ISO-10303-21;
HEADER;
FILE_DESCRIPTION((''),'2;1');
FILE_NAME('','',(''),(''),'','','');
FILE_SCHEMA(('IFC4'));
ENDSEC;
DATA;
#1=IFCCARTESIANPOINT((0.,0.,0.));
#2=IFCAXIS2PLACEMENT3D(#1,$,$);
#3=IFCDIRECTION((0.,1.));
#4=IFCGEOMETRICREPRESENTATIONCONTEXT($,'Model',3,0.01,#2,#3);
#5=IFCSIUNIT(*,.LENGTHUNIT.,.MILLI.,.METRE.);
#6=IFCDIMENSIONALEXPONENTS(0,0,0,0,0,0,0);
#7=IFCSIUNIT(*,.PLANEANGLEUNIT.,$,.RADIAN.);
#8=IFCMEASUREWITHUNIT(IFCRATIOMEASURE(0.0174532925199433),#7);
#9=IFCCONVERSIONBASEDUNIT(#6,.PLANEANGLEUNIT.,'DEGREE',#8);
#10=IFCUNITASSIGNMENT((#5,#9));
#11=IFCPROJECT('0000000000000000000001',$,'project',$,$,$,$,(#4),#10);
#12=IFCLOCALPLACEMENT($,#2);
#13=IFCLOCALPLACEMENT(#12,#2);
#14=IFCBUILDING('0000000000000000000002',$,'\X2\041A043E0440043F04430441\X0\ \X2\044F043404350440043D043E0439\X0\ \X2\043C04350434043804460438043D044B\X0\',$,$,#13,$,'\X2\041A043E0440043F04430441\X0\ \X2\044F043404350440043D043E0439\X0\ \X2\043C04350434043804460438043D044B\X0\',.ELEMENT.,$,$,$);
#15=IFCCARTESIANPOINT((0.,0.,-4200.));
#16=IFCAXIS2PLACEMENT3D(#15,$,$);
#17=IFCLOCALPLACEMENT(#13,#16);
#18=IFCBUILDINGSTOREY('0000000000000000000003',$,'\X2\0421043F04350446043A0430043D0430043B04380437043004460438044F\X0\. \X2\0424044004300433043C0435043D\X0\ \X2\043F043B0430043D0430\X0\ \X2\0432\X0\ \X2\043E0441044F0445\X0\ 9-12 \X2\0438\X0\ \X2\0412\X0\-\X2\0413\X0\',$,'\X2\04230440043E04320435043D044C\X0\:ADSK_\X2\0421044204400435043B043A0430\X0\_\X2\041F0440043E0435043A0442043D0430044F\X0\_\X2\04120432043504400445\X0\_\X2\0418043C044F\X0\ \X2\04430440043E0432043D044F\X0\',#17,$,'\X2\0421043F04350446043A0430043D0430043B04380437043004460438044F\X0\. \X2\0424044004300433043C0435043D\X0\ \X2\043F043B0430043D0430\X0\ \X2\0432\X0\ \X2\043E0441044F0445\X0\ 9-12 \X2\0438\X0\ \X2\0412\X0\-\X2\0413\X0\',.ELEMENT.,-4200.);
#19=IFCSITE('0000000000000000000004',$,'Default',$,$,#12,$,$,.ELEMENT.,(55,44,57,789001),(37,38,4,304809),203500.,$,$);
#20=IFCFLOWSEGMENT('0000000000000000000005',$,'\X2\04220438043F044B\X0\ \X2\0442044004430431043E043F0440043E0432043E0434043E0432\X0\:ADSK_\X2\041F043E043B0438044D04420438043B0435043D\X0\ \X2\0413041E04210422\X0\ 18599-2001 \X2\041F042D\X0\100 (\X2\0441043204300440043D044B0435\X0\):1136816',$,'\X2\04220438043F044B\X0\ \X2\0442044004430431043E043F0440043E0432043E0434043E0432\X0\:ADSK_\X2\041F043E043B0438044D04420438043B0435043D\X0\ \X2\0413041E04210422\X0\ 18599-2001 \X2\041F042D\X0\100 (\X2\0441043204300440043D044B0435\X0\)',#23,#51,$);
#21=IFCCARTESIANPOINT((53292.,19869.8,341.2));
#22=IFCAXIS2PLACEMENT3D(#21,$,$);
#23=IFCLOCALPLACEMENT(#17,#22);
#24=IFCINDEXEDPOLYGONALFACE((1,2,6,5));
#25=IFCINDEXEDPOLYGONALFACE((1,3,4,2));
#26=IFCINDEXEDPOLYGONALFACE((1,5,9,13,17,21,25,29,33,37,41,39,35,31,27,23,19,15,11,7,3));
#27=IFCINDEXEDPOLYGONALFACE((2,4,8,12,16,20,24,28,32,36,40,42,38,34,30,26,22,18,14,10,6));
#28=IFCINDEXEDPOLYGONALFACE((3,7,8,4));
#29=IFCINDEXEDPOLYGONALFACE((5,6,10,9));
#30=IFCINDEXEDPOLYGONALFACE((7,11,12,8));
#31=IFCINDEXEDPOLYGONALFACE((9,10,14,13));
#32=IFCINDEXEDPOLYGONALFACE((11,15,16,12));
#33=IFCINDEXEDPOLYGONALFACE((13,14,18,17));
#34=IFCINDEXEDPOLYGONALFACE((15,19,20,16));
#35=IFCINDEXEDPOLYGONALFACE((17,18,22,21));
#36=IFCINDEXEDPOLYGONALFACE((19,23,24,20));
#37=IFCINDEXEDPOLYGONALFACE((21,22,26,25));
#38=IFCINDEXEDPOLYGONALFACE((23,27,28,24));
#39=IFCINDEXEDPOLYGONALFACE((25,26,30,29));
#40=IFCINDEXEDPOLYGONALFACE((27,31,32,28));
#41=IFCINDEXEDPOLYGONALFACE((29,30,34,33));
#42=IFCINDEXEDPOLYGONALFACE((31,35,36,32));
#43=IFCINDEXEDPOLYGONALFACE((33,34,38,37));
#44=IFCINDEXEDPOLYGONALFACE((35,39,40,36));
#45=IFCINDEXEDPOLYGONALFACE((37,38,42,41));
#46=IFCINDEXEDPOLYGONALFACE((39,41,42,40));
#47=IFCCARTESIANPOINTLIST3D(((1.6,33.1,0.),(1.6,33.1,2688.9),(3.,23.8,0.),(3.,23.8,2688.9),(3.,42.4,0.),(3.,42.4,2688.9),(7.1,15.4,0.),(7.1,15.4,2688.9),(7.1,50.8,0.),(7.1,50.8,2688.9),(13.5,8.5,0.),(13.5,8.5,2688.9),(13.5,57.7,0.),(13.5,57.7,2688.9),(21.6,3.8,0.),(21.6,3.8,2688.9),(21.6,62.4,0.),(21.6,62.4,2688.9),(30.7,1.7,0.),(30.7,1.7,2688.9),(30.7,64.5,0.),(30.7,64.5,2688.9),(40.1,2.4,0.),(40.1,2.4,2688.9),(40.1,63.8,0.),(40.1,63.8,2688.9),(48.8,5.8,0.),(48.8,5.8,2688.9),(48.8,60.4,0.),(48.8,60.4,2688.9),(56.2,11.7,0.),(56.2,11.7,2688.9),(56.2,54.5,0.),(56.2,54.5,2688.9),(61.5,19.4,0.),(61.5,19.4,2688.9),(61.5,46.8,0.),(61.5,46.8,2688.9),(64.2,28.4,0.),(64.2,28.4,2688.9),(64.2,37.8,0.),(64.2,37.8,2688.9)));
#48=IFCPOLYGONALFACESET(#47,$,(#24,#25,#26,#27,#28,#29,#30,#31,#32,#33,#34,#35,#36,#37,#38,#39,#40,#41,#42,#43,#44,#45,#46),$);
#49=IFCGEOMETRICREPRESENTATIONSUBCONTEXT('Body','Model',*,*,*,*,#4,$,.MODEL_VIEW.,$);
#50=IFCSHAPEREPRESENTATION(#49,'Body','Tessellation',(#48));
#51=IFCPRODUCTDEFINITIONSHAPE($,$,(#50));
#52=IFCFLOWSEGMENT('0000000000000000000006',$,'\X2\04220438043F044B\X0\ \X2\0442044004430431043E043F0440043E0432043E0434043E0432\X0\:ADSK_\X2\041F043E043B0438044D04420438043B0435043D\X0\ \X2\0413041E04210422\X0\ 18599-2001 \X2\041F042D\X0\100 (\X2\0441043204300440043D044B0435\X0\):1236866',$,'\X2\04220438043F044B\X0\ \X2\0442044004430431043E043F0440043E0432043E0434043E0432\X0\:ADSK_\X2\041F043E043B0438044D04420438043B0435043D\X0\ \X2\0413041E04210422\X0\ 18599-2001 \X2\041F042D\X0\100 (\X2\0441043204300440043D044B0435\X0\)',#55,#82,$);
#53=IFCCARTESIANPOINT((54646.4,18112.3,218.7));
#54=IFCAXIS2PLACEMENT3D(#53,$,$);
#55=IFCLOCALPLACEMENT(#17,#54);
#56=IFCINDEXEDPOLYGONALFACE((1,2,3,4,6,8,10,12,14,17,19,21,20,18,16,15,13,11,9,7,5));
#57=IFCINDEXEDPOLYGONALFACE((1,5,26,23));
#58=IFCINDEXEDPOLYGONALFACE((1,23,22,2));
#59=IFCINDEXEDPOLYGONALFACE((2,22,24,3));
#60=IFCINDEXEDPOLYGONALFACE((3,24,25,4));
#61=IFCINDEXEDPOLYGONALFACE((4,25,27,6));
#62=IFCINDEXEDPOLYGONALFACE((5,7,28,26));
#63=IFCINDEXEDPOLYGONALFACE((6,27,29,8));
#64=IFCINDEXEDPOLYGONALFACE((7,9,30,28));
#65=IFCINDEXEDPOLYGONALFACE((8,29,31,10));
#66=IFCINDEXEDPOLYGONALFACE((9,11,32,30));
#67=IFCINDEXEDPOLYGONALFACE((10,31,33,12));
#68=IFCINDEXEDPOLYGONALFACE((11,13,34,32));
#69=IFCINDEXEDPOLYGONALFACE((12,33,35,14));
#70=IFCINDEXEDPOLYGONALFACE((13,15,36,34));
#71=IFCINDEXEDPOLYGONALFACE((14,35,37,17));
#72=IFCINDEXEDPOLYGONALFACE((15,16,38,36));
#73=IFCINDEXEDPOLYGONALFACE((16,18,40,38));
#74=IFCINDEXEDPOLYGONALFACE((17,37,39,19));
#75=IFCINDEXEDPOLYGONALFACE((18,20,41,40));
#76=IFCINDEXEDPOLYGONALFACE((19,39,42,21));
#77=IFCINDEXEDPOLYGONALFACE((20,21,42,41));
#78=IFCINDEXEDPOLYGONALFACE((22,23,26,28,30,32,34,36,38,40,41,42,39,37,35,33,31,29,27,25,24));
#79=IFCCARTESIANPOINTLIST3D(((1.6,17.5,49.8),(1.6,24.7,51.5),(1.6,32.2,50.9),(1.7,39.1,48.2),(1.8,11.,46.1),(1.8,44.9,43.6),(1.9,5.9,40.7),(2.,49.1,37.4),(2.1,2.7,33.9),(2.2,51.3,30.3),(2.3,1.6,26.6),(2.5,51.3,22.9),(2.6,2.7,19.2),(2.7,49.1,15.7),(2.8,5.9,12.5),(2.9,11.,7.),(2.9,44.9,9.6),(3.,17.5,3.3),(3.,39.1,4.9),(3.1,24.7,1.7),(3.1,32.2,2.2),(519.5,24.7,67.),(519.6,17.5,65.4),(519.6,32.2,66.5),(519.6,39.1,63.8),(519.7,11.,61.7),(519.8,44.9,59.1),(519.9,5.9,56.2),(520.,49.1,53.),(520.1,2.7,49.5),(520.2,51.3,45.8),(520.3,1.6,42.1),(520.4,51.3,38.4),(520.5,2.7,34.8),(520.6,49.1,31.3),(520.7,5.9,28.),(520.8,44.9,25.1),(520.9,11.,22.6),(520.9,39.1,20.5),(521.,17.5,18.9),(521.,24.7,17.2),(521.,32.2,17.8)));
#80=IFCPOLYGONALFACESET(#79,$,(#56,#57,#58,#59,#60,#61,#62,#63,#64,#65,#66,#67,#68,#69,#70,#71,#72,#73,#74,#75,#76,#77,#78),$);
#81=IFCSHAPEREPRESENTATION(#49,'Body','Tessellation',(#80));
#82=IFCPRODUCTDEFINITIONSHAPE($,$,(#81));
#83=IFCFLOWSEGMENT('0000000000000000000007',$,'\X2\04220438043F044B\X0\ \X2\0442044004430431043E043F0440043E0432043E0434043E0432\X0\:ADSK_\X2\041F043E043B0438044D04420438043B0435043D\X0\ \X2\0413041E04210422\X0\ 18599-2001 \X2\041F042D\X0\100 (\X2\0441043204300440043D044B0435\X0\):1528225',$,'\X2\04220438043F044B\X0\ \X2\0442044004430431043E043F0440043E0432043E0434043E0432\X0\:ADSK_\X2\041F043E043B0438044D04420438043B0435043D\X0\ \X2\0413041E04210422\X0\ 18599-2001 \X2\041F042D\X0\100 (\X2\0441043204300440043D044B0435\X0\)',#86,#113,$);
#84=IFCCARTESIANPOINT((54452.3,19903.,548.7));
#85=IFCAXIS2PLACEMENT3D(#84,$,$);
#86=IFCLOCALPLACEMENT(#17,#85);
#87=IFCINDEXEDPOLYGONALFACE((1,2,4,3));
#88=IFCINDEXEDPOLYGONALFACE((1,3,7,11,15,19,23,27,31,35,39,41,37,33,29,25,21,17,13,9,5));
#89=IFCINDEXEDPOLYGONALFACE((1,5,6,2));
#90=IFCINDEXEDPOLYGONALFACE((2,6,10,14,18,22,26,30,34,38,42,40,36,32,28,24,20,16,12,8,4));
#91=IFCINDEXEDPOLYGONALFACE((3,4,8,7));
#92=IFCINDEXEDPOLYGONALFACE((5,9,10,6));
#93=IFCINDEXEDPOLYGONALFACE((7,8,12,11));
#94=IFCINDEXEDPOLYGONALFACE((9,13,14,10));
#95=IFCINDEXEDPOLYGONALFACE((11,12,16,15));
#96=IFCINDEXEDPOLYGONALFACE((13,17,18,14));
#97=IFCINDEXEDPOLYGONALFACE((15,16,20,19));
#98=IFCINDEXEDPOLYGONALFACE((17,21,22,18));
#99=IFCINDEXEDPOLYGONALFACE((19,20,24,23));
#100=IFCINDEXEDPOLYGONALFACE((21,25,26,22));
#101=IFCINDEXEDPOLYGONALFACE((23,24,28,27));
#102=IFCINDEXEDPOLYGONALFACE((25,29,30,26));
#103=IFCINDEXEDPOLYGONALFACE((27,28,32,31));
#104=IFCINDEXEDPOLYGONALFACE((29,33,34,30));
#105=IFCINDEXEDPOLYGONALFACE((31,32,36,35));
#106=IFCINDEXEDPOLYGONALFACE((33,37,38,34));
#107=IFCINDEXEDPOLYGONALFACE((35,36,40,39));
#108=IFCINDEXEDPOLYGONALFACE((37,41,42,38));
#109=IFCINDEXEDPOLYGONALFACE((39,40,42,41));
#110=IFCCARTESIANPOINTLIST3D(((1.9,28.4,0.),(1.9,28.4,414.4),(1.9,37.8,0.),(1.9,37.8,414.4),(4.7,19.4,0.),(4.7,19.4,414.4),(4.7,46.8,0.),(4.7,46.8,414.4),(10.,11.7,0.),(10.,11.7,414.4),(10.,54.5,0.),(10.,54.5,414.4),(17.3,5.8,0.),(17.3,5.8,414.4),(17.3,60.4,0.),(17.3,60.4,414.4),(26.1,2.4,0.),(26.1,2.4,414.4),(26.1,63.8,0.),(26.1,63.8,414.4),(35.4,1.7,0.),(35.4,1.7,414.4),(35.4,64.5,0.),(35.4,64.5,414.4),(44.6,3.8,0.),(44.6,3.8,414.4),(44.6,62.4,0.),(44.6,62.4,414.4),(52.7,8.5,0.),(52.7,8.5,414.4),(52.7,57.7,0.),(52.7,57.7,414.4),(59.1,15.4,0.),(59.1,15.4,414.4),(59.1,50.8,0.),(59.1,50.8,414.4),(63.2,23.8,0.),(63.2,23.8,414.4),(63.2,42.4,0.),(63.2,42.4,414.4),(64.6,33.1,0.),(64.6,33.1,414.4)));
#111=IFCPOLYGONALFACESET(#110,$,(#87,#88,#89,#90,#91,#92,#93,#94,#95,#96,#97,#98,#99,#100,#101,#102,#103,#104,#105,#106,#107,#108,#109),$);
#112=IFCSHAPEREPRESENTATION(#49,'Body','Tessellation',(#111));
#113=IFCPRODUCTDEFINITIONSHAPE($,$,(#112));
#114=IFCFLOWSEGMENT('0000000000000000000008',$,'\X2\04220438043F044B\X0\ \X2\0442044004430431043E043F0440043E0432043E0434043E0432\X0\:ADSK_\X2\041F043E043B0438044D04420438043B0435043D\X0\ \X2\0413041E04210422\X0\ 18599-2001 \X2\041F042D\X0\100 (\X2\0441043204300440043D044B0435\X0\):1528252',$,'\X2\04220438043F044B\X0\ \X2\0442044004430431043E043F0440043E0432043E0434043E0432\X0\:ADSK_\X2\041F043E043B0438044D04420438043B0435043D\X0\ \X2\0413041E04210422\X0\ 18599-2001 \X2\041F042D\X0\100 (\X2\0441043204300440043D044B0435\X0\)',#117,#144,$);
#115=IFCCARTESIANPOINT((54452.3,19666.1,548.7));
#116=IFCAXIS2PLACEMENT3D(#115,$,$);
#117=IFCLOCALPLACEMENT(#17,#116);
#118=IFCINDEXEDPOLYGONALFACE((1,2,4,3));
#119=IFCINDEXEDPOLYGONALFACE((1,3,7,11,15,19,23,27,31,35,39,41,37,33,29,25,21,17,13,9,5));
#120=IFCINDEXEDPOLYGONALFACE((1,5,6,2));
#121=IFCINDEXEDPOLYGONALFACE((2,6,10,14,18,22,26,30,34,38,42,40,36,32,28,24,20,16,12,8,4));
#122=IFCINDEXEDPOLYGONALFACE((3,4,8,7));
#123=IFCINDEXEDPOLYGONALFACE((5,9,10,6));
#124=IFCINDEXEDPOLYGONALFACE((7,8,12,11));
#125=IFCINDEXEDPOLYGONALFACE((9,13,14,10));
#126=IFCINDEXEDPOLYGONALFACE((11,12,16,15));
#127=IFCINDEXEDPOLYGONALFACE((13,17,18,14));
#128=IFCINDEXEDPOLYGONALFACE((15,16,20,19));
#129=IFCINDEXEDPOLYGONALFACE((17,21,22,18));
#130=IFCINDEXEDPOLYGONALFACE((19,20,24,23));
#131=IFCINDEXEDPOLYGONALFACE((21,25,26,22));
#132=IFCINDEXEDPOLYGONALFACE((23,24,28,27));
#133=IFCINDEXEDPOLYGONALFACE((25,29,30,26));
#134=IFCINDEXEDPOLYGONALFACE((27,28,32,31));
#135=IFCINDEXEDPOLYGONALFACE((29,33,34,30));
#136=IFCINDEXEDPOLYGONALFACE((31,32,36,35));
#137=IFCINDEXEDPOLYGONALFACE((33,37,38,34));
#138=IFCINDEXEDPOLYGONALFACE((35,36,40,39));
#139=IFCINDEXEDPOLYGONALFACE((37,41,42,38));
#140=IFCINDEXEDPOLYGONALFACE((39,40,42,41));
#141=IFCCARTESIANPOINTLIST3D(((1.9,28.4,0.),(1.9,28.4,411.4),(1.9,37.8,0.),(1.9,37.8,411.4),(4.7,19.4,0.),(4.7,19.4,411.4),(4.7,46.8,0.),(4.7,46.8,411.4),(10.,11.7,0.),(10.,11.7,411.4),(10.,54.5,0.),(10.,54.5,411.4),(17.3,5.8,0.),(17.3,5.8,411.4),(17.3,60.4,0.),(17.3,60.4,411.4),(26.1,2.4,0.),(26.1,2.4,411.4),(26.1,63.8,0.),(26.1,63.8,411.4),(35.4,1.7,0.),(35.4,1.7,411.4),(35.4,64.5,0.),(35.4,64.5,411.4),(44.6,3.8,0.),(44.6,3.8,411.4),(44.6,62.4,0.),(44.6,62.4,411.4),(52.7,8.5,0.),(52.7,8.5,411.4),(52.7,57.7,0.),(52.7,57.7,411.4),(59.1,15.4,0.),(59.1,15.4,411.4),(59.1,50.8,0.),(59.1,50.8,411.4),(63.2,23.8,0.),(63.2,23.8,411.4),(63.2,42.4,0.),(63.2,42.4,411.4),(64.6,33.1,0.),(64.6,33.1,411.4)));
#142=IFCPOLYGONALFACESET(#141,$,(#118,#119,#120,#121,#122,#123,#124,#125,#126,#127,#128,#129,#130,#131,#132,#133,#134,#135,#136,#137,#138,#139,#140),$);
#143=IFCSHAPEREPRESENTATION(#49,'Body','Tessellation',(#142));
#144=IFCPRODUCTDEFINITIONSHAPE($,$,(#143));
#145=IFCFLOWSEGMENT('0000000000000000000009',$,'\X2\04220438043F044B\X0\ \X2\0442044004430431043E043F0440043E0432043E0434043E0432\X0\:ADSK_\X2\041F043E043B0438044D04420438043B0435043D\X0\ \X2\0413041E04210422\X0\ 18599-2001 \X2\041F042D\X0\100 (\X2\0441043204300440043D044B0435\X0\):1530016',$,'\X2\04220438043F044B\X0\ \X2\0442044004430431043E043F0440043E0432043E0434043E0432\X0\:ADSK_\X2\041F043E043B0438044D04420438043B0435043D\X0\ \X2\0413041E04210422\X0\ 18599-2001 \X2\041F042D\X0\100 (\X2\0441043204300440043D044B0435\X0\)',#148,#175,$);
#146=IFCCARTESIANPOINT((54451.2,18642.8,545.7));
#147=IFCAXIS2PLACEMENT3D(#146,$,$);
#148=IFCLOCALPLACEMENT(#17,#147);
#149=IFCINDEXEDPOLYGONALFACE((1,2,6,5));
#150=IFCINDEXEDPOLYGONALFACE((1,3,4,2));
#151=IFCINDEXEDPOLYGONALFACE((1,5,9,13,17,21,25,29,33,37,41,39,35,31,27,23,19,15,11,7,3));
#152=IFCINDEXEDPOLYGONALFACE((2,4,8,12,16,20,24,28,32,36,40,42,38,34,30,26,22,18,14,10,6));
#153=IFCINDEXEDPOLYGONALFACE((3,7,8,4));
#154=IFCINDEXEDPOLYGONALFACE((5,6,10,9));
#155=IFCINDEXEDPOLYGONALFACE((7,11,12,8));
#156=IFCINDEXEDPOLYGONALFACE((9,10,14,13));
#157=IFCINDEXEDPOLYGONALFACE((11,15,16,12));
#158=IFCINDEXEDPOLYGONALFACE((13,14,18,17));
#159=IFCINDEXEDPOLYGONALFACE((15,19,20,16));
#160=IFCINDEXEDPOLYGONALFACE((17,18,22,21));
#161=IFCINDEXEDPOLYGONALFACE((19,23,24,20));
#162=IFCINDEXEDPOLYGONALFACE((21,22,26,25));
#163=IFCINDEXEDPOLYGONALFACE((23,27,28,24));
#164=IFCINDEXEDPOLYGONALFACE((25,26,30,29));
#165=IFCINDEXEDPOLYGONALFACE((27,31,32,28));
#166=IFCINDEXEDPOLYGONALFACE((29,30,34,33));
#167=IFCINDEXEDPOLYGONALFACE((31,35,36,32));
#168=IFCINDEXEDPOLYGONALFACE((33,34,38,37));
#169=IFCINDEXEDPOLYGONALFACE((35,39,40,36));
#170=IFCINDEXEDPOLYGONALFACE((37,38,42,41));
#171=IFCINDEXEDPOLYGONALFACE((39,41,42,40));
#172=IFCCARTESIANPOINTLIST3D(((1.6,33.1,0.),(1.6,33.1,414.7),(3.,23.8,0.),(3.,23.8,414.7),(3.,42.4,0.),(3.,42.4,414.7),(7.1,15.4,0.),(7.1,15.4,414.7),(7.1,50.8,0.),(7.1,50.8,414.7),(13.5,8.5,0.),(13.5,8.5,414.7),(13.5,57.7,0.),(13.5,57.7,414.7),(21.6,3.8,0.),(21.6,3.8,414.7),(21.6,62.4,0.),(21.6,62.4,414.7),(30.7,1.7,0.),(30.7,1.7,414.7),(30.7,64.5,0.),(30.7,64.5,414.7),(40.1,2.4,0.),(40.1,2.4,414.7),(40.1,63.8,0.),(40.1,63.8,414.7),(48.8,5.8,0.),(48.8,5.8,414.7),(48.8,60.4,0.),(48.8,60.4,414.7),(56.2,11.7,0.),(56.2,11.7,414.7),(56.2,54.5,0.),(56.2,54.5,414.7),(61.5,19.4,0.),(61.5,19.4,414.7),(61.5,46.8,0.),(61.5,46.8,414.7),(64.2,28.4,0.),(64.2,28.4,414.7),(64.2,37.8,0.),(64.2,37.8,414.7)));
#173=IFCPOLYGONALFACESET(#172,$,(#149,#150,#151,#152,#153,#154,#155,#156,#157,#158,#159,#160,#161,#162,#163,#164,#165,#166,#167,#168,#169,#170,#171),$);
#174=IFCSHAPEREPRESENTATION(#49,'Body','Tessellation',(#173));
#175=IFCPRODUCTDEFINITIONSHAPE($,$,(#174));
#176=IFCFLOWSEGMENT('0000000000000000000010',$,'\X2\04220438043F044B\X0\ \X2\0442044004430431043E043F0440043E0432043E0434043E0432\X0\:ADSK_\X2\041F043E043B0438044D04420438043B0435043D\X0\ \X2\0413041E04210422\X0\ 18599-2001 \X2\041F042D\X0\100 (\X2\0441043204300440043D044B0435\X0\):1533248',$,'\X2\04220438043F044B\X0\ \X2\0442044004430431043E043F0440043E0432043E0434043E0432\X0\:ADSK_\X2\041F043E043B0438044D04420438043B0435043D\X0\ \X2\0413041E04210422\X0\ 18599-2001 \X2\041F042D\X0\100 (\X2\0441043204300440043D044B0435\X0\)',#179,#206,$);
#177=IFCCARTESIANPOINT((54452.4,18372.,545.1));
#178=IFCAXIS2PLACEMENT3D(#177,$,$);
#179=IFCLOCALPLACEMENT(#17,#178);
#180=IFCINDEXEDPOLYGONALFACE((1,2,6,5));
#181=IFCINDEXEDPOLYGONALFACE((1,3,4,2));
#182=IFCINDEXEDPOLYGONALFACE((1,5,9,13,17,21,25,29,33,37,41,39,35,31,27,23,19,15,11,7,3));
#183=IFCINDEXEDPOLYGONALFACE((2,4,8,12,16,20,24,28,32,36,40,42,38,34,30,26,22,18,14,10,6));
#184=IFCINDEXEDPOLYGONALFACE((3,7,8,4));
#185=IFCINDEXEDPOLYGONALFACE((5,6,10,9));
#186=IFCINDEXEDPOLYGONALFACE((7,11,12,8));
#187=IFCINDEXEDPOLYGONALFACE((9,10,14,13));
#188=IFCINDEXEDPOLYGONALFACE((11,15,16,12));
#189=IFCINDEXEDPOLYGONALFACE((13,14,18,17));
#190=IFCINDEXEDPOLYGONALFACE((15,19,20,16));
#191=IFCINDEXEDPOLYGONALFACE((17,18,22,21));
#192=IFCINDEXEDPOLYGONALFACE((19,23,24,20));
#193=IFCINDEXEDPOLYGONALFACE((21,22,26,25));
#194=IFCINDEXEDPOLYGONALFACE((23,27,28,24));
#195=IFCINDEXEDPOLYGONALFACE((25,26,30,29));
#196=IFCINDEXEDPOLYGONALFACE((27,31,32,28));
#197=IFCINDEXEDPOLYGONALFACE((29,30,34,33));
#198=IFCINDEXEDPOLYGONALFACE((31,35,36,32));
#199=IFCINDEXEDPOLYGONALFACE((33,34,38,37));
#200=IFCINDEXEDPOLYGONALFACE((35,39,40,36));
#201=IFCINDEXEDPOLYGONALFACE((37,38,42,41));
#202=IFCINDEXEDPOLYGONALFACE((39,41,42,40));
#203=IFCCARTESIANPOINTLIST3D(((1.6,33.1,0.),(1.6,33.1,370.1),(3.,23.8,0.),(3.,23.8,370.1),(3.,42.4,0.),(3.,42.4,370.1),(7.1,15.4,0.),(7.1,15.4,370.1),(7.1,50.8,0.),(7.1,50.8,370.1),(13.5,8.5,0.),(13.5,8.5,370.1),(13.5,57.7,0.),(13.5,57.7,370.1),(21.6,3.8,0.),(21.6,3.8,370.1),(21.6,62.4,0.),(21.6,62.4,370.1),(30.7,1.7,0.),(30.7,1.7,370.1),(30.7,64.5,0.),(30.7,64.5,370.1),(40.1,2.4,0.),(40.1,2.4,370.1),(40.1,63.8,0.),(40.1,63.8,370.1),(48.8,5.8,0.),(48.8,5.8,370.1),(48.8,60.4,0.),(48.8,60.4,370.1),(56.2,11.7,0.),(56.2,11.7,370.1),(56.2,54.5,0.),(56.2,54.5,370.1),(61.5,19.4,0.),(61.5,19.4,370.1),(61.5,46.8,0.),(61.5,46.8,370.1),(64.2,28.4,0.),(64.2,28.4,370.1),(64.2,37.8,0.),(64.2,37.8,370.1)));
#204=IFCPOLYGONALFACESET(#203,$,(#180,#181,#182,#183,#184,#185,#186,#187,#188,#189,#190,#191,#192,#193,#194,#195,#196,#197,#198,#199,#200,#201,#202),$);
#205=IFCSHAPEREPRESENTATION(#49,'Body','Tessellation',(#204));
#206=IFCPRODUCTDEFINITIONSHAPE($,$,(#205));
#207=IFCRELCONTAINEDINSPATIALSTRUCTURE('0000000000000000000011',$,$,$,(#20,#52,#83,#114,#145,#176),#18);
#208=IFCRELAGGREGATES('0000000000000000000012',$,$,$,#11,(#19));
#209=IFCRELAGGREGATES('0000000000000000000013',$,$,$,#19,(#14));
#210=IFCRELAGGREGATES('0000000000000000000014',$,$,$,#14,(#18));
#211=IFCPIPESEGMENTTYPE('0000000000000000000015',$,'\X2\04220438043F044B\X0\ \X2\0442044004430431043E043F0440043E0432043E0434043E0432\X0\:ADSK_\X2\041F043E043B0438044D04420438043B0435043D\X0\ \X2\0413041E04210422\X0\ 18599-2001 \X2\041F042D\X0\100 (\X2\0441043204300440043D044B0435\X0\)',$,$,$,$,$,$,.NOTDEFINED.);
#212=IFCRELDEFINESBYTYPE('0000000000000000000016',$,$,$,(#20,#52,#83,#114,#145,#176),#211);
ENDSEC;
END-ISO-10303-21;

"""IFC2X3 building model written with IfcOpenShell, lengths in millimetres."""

from ifc_helpers import new_model, entity, si_unit, converted_unit, direction, frame, frame_2d, origin, origin_2d_with_axis, place, context, subcontext, project, spatial, circle, extrude, type_object, element, save


model = new_model("IFC2X3")

# Units and contexts
model_context = context("Model", 3, precision=0.01, world=origin(), true_north=direction((0.0, 1.0)))
body_context = subcontext(model_context, "Body", "Model", "MODEL_VIEW")
ifc_project = project(units=[si_unit("LENGTHUNIT", "METRE", prefix="MILLI"), converted_unit("PLANEANGLEUNIT", "DEGREE", entity("IfcRatioMeasure", 0.0174532925199433), si_unit("PLANEANGLEUNIT", "RADIAN"), dimensions=[0, 0, 0, 0, 0, 0, 0])], contexts=[model_context])

# Site, building, storey
site_placement = place(None, frame((0.0, 0.0, 0.0)))
site = spatial("IfcSite", under=ifc_project, at=site_placement, Name="Default", CompositionType="ELEMENT", RefLatitude=(55, 44, 57, 789001), RefLongitude=(37, 38, 4, 304809), RefElevation=203500.0)
building_placement = place(site_placement, origin())
building = spatial("IfcBuilding", under=site, at=building_placement, Name="Корпус ядерной медицины", LongName="Корпус ядерной медицины", CompositionType="ELEMENT")
storey_placement = place(building_placement, frame((0.0, 0.0, -4200.0)))
storey = spatial("IfcBuildingStorey", under=building, at=storey_placement, Name="Спецканализация. Фрагмен плана в осях 9-12 и В-Г", ObjectType="Уровень:ADSK_Стрелка_Проектная_Вверх_Имя уровня", LongName="Спецканализация. Фрагмен плана в осях 9-12 и В-Г", CompositionType="ELEMENT", Elevation=-4200.0)

# Flow segments
pipe_segment_type = type_object("IfcPipeSegmentType", Name="Типы трубопроводов:ADSK_Полиэтилен ГОСТ 18599-2001 ПЭ100 (сварные)", PredefinedType="NOTDEFINED")
flow_segment_1_placement = place(storey_placement, frame((53292.0, 19869.8, 341.2)))
element("IfcFlowSegment", 1, at=flow_segment_1_placement, inside=storey, type_object=pipe_segment_type, Name="Типы трубопроводов:ADSK_Полиэтилен ГОСТ 18599-2001 ПЭ100 (сварные):1136816", ObjectType="Типы трубопроводов:ADSK_Полиэтилен ГОСТ 18599-2001 ПЭ100 (сварные)", context=body_context, shape_type="SweptSolid", body=[
    extrude(circle(Radius=31.5, at=origin_2d_with_axis()), frame((33.1, 33.1, 0.0), z_axis=(0.0, 0.0, 1.0), x_axis=(-1.0, 0.0, 0.0)), (0.0, 0.0, 1.0), 2688.9),
])
flow_segment_2_placement = place(storey_placement, frame((54646.4, 18112.3, 218.7)))
element("IfcFlowSegment", 2, at=flow_segment_2_placement, inside=storey, type_object=pipe_segment_type, Name="Типы трубопроводов:ADSK_Полиэтилен ГОСТ 18599-2001 ПЭ100 (сварные):1236866", ObjectType="Типы трубопроводов:ADSK_Полиэтилен ГОСТ 18599-2001 ПЭ100 (сварные)", context=body_context, shape_type="SweptSolid", body=[
    extrude(circle(Radius=25.0, at=origin_2d_with_axis()), frame((2.3, 26.6, 26.6), z_axis=(0.99955, 0.0, 0.029987), x_axis=(0.0, -1.0, 0.0)), (0.0, 0.0, 1.0), 518.2),
])
flow_segment_3_placement = place(storey_placement, frame((54452.3, 19903.0, 548.7)))
element("IfcFlowSegment", 3, at=flow_segment_3_placement, inside=storey, type_object=pipe_segment_type, Name="Типы трубопроводов:ADSK_Полиэтилен ГОСТ 18599-2001 ПЭ100 (сварные):1528225", ObjectType="Типы трубопроводов:ADSK_Полиэтилен ГОСТ 18599-2001 ПЭ100 (сварные)", context=body_context, shape_type="SweptSolid", body=[
    extrude(circle(Radius=31.5, at=origin_2d_with_axis()), frame((33.1, 33.1, 0.0)), (0.0, 0.0, 1.0), 414.4),
])
flow_segment_4_placement = place(storey_placement, frame((54452.3, 19666.1, 548.7)))
element("IfcFlowSegment", 4, at=flow_segment_4_placement, inside=storey, type_object=pipe_segment_type, Name="Типы трубопроводов:ADSK_Полиэтилен ГОСТ 18599-2001 ПЭ100 (сварные):1528252", ObjectType="Типы трубопроводов:ADSK_Полиэтилен ГОСТ 18599-2001 ПЭ100 (сварные)", context=body_context, shape_type="SweptSolid", body=[
    extrude(circle(Radius=31.5, at=origin_2d_with_axis()), frame((33.1, 33.1, 0.0)), (0.0, 0.0, 1.0), 411.4),
])
flow_segment_5_placement = place(storey_placement, frame((54451.2, 18642.8, 545.7)))
element("IfcFlowSegment", 5, at=flow_segment_5_placement, inside=storey, type_object=pipe_segment_type, Name="Типы трубопроводов:ADSK_Полиэтилен ГОСТ 18599-2001 ПЭ100 (сварные):1530016", ObjectType="Типы трубопроводов:ADSK_Полиэтилен ГОСТ 18599-2001 ПЭ100 (сварные)", context=body_context, shape_type="SweptSolid", body=[
    extrude(circle(Radius=31.5, at=frame_2d((0.0, 0.0), x_axis=(1.0, 0.0))), frame((33.1, 33.1, 0.0), z_axis=(0.0, 0.0, 1.0), x_axis=(-1.0, 0.0, 0.0)), (0.0, 0.0, 1.0), 414.7),
])
flow_segment_6_placement = place(storey_placement, frame((54452.4, 18372.0, 545.1)))
element("IfcFlowSegment", 6, at=flow_segment_6_placement, inside=storey, type_object=pipe_segment_type, Name="Типы трубопроводов:ADSK_Полиэтилен ГОСТ 18599-2001 ПЭ100 (сварные):1533248", ObjectType="Типы трубопроводов:ADSK_Полиэтилен ГОСТ 18599-2001 ПЭ100 (сварные)", context=body_context, shape_type="SweptSolid", body=[
    extrude(circle(Radius=31.5, at=origin_2d_with_axis()), frame((33.1, 33.1, 0.0), z_axis=(0.0, 0.0, 1.0), x_axis=(-1.0, 0.0, 0.0)), (0.0, 0.0, 1.0), 370.1),
])

save(model, "model.ifc")
